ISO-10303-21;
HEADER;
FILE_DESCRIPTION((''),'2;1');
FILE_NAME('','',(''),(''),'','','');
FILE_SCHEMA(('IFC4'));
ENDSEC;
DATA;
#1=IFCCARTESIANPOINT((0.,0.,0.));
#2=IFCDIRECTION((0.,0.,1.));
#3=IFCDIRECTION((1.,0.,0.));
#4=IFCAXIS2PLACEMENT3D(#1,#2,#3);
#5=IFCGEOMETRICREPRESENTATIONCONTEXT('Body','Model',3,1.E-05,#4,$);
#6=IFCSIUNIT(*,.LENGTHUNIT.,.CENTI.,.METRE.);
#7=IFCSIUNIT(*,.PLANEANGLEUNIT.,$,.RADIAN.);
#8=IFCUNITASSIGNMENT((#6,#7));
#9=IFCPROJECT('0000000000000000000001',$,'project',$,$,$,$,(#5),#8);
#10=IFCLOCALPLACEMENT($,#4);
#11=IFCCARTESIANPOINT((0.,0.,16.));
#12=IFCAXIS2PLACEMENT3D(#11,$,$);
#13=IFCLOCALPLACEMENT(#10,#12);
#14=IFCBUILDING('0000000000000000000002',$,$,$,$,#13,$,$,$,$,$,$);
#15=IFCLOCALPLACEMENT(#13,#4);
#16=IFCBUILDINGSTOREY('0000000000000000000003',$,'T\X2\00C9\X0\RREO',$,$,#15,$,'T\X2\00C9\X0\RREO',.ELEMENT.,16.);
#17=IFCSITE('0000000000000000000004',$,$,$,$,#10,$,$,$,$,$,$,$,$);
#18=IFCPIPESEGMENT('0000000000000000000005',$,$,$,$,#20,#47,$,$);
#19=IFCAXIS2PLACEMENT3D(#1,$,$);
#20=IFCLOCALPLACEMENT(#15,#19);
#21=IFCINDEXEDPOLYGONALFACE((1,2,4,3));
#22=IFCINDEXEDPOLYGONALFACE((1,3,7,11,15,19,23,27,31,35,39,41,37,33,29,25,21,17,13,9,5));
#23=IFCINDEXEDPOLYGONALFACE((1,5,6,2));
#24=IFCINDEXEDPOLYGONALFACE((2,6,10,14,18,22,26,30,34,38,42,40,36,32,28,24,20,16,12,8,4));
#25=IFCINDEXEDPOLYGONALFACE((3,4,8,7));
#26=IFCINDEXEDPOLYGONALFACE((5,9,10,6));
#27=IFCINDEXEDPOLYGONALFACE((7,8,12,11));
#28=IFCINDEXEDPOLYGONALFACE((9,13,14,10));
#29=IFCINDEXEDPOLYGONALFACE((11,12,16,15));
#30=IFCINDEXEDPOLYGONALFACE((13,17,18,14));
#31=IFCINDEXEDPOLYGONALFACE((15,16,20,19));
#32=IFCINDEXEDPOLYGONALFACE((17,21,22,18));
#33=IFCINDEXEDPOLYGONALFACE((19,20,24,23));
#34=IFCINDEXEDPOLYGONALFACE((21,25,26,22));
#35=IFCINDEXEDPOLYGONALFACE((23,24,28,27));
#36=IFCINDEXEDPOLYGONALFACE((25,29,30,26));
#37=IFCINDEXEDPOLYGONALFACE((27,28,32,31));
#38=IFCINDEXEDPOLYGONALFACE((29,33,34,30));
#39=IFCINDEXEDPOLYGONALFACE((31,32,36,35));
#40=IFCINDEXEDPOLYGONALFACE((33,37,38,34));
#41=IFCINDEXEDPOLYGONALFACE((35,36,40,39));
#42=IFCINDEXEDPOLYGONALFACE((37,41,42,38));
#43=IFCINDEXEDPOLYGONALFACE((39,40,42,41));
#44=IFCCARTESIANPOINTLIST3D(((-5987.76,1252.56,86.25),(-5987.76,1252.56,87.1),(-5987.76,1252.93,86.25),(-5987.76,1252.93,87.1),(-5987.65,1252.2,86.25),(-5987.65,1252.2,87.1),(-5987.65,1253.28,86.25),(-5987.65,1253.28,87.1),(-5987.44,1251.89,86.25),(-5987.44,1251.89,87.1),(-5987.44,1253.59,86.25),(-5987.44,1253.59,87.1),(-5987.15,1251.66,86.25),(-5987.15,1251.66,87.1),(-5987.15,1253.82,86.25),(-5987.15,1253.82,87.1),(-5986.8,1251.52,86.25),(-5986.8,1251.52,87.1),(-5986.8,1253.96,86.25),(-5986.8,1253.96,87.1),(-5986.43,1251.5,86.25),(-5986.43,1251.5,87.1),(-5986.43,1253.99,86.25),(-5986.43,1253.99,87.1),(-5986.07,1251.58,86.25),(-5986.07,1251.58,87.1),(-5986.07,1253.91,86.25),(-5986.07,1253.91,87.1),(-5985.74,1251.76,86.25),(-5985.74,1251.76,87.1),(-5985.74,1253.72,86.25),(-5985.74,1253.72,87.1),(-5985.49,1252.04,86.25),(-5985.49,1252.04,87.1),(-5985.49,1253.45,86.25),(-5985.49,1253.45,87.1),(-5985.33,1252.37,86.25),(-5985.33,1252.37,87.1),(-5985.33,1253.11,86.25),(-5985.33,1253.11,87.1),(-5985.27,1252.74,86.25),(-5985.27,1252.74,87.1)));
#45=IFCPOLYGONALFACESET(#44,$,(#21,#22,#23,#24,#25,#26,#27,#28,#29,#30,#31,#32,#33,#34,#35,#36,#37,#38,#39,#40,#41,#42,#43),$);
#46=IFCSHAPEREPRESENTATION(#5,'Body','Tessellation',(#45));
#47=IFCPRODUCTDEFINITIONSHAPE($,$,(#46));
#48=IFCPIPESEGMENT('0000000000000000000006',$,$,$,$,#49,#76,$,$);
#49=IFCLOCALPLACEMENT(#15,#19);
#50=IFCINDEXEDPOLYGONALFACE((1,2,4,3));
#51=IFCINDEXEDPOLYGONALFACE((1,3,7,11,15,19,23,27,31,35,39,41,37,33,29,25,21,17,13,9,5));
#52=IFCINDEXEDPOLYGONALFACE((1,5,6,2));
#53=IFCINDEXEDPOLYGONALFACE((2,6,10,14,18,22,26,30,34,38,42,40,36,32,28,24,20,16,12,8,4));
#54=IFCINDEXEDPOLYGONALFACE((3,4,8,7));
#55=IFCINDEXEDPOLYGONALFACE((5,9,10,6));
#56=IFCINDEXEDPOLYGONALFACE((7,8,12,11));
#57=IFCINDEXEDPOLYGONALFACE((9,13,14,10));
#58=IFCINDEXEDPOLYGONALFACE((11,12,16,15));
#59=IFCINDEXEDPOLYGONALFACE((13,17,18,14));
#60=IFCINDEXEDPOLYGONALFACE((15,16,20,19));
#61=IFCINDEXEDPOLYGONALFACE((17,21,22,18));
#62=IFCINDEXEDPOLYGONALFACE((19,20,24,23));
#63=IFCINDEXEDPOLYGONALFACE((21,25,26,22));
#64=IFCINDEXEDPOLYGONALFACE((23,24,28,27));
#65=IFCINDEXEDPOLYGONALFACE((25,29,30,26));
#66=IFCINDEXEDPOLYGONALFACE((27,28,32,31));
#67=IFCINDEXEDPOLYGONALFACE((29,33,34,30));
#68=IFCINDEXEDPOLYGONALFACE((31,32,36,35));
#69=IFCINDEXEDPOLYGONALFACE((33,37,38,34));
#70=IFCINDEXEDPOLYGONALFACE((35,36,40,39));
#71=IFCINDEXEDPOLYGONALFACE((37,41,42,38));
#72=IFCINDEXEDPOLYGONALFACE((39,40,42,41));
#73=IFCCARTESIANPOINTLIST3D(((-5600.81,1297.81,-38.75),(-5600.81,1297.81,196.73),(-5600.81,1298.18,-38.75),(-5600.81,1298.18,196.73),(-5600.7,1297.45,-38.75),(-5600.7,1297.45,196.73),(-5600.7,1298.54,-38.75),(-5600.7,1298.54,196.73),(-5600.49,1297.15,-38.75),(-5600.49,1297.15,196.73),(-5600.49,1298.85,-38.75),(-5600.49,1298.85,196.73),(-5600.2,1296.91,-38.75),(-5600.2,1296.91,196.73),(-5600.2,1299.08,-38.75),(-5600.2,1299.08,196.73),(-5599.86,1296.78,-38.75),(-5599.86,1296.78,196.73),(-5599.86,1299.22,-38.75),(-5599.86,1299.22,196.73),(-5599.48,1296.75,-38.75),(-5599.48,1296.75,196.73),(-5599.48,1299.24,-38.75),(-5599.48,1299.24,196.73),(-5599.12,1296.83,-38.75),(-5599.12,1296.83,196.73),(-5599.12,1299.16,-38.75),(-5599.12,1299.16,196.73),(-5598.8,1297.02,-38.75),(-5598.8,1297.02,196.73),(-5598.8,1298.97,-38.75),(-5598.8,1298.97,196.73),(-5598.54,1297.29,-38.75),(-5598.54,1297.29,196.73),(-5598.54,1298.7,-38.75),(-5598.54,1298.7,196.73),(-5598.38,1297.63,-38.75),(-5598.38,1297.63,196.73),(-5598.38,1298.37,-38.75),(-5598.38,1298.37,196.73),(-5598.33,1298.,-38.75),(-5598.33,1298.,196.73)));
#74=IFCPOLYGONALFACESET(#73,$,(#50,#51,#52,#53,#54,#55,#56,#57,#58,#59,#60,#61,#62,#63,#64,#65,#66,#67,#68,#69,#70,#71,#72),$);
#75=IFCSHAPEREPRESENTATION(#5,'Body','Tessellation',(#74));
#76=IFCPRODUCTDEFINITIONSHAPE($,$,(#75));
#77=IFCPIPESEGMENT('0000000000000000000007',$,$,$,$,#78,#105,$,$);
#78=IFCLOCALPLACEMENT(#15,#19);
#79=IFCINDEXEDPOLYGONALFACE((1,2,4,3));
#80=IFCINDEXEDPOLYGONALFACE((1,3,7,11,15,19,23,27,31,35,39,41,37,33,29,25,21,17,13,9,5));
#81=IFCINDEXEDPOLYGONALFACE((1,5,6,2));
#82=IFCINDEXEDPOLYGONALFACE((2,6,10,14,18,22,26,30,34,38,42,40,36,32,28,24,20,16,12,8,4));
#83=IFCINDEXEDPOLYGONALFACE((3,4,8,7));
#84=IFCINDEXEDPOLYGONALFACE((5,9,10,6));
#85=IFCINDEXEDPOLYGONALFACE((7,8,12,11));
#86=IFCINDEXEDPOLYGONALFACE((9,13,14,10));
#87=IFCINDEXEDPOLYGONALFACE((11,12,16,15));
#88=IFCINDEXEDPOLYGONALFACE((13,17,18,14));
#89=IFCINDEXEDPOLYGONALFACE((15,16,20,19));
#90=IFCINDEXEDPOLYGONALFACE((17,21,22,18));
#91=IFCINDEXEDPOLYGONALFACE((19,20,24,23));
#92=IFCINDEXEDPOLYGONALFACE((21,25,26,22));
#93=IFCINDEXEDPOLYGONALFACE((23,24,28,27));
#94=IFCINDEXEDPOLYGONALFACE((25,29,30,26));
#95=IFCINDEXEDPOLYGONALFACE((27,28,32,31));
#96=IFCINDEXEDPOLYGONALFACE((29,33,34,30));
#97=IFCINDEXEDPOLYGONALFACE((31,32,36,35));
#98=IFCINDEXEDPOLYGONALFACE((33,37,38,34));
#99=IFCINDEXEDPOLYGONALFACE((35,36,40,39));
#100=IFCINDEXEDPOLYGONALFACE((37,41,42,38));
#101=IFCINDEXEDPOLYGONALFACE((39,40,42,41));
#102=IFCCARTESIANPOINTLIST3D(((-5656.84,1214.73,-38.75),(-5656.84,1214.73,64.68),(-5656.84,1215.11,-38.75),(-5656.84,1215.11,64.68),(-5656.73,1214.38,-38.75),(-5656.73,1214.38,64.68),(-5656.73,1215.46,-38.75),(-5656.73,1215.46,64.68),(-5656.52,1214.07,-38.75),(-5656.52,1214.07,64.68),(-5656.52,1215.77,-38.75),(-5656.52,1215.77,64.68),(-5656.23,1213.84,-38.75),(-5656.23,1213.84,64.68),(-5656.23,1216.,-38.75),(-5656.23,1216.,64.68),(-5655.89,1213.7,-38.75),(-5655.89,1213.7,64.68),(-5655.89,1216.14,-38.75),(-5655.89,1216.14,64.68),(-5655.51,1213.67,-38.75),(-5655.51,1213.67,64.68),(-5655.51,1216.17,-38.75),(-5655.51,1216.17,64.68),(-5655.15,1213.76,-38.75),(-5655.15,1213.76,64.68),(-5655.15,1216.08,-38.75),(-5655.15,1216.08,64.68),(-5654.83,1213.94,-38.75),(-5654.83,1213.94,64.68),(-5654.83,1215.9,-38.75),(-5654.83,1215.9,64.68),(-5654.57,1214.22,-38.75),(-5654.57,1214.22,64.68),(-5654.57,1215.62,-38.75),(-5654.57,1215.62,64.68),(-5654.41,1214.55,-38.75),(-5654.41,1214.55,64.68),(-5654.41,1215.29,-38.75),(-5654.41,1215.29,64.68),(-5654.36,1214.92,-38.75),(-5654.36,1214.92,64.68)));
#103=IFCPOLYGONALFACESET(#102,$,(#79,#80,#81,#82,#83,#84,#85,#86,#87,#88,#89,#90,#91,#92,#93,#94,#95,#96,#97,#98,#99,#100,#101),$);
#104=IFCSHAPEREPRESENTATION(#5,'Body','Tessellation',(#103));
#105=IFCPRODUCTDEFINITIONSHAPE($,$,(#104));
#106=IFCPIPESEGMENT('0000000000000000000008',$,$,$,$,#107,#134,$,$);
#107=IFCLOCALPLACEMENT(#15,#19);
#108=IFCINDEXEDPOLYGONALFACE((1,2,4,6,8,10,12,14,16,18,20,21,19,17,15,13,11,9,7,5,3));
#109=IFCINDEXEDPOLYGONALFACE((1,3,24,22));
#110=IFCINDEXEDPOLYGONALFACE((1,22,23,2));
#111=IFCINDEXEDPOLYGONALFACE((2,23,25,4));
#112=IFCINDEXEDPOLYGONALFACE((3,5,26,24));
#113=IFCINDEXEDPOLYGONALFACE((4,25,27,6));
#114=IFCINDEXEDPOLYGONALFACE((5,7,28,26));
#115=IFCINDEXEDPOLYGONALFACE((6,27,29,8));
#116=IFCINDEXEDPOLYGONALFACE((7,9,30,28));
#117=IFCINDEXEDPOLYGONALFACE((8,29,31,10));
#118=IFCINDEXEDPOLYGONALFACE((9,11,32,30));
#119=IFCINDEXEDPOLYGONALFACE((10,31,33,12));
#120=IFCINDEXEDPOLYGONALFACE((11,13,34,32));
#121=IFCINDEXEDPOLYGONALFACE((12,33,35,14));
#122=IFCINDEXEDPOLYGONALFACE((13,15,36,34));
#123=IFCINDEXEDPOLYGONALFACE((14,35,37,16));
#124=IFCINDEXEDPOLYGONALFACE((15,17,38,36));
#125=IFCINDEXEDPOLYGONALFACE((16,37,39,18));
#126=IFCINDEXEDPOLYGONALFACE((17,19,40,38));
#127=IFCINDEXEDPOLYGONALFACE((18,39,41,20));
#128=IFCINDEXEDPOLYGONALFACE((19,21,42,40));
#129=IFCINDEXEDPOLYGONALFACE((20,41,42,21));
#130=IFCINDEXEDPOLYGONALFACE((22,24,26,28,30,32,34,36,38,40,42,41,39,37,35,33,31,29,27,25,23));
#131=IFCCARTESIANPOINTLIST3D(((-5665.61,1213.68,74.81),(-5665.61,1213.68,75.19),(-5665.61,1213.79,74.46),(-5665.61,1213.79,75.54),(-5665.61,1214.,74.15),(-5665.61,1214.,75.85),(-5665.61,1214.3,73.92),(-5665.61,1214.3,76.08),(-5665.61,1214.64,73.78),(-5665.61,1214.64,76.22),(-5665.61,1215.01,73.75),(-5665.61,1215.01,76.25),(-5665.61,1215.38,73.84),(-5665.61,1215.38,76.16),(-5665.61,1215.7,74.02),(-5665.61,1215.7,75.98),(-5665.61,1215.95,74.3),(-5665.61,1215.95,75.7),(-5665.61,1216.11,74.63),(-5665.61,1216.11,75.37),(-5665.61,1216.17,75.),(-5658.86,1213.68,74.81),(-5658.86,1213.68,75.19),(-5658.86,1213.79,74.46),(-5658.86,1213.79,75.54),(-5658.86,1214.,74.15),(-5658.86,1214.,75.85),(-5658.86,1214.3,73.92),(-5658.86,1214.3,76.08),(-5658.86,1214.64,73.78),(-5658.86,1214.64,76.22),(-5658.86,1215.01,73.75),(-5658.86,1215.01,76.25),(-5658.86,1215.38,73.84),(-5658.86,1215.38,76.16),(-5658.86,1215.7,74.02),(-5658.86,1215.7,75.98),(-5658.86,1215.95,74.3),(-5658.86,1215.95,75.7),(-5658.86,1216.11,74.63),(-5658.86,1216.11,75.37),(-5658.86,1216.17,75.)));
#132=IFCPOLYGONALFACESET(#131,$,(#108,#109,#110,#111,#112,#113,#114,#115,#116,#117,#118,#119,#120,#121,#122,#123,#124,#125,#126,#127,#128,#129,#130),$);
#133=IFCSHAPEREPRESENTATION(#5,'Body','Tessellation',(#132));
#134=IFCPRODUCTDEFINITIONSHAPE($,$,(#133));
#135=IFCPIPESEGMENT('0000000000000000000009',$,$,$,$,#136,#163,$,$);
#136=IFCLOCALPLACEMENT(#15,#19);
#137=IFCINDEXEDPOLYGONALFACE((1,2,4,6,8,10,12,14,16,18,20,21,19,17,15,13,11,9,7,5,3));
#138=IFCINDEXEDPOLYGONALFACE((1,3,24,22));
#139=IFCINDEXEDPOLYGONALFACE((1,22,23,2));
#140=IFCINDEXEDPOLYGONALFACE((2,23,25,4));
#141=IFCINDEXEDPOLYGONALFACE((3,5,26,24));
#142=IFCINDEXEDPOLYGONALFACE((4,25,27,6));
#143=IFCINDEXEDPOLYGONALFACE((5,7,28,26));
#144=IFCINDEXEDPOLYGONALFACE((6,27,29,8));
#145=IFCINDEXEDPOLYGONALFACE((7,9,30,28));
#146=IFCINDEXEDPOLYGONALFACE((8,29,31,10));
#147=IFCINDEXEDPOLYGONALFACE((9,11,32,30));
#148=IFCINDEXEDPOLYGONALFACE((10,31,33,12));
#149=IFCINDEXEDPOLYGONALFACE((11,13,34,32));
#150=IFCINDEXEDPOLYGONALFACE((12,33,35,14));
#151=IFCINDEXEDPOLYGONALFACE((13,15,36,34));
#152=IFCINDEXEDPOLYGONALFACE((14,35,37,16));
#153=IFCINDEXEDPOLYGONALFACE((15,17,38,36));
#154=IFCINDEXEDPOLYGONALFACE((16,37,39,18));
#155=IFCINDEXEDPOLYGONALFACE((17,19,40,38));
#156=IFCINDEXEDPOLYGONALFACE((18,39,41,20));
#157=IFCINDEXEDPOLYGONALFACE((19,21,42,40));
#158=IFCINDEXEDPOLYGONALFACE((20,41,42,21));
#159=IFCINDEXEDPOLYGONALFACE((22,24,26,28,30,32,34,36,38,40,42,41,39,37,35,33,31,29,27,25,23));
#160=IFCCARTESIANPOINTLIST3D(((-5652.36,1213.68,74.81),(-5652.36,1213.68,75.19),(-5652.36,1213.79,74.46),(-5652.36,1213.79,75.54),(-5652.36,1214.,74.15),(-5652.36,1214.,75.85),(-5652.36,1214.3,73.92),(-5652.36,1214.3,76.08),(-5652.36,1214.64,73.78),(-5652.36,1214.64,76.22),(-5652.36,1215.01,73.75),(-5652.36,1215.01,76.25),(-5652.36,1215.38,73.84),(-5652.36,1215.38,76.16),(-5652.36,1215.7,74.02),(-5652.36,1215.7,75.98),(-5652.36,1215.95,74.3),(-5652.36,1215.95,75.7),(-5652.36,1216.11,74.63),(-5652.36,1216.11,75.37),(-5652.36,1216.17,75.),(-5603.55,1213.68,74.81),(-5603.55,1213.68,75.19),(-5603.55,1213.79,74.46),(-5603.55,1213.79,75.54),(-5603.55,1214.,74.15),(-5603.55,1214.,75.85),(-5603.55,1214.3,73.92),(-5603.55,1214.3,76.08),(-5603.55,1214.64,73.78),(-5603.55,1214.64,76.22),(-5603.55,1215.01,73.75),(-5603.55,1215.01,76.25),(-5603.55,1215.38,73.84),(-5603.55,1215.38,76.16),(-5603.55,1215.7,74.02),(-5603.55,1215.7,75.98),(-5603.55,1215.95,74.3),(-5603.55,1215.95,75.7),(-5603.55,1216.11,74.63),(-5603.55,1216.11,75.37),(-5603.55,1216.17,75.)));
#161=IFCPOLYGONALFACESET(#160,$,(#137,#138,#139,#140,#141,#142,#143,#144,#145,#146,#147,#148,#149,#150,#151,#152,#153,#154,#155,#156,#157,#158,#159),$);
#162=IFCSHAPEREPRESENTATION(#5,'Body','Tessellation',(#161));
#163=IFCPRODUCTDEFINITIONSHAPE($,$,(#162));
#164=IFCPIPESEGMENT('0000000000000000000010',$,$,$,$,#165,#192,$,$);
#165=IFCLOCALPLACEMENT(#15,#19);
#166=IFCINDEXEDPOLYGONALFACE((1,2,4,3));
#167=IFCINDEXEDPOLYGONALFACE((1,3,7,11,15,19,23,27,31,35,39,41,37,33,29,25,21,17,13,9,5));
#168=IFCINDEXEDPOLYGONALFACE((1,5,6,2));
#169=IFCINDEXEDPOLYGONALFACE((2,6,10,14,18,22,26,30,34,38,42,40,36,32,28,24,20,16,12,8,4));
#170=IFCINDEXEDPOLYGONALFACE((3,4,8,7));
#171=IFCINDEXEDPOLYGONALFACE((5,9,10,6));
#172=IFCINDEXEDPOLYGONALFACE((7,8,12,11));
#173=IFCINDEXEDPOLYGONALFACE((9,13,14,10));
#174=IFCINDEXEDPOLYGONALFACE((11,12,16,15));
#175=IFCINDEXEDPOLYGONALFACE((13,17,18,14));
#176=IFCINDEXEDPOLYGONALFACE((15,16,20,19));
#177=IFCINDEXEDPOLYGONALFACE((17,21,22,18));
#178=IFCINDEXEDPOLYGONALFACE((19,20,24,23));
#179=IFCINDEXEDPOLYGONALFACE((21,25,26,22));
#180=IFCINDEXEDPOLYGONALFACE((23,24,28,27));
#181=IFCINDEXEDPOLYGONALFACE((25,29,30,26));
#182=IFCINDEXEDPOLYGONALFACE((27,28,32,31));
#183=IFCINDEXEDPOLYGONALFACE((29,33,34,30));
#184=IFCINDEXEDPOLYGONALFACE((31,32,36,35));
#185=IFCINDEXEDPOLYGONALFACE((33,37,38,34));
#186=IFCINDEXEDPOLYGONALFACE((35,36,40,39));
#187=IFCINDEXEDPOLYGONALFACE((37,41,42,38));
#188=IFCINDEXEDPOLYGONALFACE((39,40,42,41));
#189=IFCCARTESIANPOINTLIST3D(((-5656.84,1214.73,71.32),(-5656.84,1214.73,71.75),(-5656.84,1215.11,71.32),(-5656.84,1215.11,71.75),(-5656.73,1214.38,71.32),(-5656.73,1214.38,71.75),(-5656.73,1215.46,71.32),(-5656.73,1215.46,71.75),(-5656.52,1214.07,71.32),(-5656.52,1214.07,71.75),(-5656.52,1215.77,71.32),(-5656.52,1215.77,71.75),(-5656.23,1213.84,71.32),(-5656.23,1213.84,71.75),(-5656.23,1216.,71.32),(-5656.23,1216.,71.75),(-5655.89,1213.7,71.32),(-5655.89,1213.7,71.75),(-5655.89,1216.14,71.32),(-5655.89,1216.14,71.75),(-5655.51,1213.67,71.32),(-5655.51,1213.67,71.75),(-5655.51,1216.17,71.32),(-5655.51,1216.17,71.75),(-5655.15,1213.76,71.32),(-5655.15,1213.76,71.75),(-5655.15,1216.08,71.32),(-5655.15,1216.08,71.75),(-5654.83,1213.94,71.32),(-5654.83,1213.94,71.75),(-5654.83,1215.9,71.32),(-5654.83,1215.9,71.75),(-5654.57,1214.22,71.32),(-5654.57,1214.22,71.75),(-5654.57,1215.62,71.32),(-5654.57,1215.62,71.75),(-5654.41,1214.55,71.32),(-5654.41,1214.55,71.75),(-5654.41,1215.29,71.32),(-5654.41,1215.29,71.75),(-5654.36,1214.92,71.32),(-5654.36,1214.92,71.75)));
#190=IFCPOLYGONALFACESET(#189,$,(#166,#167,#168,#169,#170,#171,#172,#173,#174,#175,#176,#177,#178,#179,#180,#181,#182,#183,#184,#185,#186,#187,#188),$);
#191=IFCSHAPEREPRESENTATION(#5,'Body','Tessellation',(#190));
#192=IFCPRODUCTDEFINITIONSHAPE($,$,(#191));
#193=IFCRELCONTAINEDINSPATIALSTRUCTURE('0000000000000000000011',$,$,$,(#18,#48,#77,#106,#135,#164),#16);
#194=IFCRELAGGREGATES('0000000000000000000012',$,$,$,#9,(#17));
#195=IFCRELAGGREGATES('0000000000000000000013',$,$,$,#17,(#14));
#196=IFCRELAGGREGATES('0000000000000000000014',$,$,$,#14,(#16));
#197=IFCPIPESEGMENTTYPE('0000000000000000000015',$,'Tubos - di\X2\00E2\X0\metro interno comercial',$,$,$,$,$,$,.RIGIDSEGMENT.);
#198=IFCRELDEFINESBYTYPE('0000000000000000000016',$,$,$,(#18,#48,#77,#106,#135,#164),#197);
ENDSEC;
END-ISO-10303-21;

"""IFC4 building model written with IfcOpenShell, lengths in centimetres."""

from ifc_helpers import new_model, si_unit, frame, origin_with_axes, origin_2d_with_axis, place, context, project, spatial, circle, extrude, type_object, element, save


model = new_model("IFC4")

# Units and contexts
model_context = context("Model", 3, precision=1e-05, world=origin_with_axes(), identifier="Body")
ifc_project = project(units=[si_unit("LENGTHUNIT", "METRE", prefix="CENTI"), si_unit("PLANEANGLEUNIT", "RADIAN")], contexts=[model_context])

# Site, building, storey
site_placement = place(None, origin_with_axes())
site = spatial("IfcSite", under=ifc_project, at=site_placement)
building_placement = place(site_placement, frame((0.0, 0.0, 16.0)))
building = spatial("IfcBuilding", under=site, at=building_placement)
storey_placement = place(building_placement, origin_with_axes())
storey = spatial("IfcBuildingStorey", under=building, at=storey_placement, Name="TÉRREO", LongName="TÉRREO", CompositionType="ELEMENT", Elevation=16.0)

# Pipe segments
pipe_segment_type = type_object("IfcPipeSegmentType", Name="Tubos - diâmetro interno comercial", PredefinedType="RIGIDSEGMENT")
pipe_segment_1_placement = place(storey_placement, frame((-5986.52, 1252.74, 87.1), z_axis=(0.0, 0.0, 1.0), x_axis=(1.0, 0.0, 0.0)))
element("IfcPipeSegment", 1, at=pipe_segment_1_placement, inside=storey, type_object=pipe_segment_type, context=model_context, shape_type="SolidModel", body=[
    extrude(circle(Radius=1.25, at=origin_2d_with_axis()), frame((0.0, 0.0, -0.85), z_axis=(0.0, 0.0, 1.0), x_axis=(1.0, 0.0, 0.0)), (0.0, 0.0, 1.0), 0.85),
])
pipe_segment_2_placement = place(storey_placement, frame((-5599.58, 1298.0, 196.73), z_axis=(0.0, 0.0, 1.0), x_axis=(1.0, 0.0, 0.0)))
element("IfcPipeSegment", 2, at=pipe_segment_2_placement, inside=storey, type_object=pipe_segment_type, context=model_context, shape_type="SolidModel", body=[
    extrude(circle(Radius=1.25, at=origin_2d_with_axis()), frame((0.0, 0.0, -235.48), z_axis=(0.0, 0.0, 1.0), x_axis=(1.0, 0.0, 0.0)), (0.0, 0.0, 1.0), 235.48),
])
pipe_segment_3_placement = place(storey_placement, frame((-5655.61, 1214.92, 64.68), z_axis=(0.0, 0.0, 1.0), x_axis=(1.0, 0.0, 0.0)))
element("IfcPipeSegment", 3, at=pipe_segment_3_placement, inside=storey, type_object=pipe_segment_type, context=model_context, shape_type="SolidModel", body=[
    extrude(circle(Radius=1.25, at=origin_2d_with_axis()), frame((0.0, 0.0, 0.0), z_axis=(0.0, 0.0, -1.0), x_axis=(1.0, 0.0, 0.0)), (0.0, 0.0, 1.0), 103.43),
])
pipe_segment_4_placement = place(storey_placement, frame((-5662.24, 1214.92, 76.25), z_axis=(0.0, 0.0, 1.0), x_axis=(1.0, 0.0, 0.0)))
element("IfcPipeSegment", 4, at=pipe_segment_4_placement, inside=storey, type_object=pipe_segment_type, context=model_context, shape_type="SolidModel", body=[
    extrude(circle(Radius=1.25, at=origin_2d_with_axis()), frame((-3.38, 0.0, -1.25), z_axis=(1.0, 0.0, 0.0), x_axis=(0.0, 1.0, 0.0)), (0.0, 0.0, 1.0), 6.76),
])
pipe_segment_5_placement = place(storey_placement, frame((-5627.95, 1214.92, 76.25), z_axis=(0.0, 0.0, 1.0), x_axis=(1.0, 0.0, 0.0)))
element("IfcPipeSegment", 5, at=pipe_segment_5_placement, inside=storey, type_object=pipe_segment_type, context=model_context, shape_type="SolidModel", body=[
    extrude(circle(Radius=1.25, at=origin_2d_with_axis()), frame((-24.41, 0.0, -1.25), z_axis=(1.0, 0.0, 0.0), x_axis=(0.0, 1.0, 0.0)), (0.0, 0.0, 1.0), 48.81),
])
pipe_segment_6_placement = place(storey_placement, frame((-5655.61, 1214.92, 71.75), z_axis=(0.0, 0.0, 1.0), x_axis=(1.0, 0.0, 0.0)))
element("IfcPipeSegment", 6, at=pipe_segment_6_placement, inside=storey, type_object=pipe_segment_type, context=model_context, shape_type="SolidModel", body=[
    extrude(circle(Radius=1.25, at=origin_2d_with_axis()), frame((0.0, 0.0, 0.0), z_axis=(0.0, 0.0, -1.0), x_axis=(1.0, 0.0, 0.0)), (0.0, 0.0, 1.0), 0.43),
])

save(model, "model.ifc")
